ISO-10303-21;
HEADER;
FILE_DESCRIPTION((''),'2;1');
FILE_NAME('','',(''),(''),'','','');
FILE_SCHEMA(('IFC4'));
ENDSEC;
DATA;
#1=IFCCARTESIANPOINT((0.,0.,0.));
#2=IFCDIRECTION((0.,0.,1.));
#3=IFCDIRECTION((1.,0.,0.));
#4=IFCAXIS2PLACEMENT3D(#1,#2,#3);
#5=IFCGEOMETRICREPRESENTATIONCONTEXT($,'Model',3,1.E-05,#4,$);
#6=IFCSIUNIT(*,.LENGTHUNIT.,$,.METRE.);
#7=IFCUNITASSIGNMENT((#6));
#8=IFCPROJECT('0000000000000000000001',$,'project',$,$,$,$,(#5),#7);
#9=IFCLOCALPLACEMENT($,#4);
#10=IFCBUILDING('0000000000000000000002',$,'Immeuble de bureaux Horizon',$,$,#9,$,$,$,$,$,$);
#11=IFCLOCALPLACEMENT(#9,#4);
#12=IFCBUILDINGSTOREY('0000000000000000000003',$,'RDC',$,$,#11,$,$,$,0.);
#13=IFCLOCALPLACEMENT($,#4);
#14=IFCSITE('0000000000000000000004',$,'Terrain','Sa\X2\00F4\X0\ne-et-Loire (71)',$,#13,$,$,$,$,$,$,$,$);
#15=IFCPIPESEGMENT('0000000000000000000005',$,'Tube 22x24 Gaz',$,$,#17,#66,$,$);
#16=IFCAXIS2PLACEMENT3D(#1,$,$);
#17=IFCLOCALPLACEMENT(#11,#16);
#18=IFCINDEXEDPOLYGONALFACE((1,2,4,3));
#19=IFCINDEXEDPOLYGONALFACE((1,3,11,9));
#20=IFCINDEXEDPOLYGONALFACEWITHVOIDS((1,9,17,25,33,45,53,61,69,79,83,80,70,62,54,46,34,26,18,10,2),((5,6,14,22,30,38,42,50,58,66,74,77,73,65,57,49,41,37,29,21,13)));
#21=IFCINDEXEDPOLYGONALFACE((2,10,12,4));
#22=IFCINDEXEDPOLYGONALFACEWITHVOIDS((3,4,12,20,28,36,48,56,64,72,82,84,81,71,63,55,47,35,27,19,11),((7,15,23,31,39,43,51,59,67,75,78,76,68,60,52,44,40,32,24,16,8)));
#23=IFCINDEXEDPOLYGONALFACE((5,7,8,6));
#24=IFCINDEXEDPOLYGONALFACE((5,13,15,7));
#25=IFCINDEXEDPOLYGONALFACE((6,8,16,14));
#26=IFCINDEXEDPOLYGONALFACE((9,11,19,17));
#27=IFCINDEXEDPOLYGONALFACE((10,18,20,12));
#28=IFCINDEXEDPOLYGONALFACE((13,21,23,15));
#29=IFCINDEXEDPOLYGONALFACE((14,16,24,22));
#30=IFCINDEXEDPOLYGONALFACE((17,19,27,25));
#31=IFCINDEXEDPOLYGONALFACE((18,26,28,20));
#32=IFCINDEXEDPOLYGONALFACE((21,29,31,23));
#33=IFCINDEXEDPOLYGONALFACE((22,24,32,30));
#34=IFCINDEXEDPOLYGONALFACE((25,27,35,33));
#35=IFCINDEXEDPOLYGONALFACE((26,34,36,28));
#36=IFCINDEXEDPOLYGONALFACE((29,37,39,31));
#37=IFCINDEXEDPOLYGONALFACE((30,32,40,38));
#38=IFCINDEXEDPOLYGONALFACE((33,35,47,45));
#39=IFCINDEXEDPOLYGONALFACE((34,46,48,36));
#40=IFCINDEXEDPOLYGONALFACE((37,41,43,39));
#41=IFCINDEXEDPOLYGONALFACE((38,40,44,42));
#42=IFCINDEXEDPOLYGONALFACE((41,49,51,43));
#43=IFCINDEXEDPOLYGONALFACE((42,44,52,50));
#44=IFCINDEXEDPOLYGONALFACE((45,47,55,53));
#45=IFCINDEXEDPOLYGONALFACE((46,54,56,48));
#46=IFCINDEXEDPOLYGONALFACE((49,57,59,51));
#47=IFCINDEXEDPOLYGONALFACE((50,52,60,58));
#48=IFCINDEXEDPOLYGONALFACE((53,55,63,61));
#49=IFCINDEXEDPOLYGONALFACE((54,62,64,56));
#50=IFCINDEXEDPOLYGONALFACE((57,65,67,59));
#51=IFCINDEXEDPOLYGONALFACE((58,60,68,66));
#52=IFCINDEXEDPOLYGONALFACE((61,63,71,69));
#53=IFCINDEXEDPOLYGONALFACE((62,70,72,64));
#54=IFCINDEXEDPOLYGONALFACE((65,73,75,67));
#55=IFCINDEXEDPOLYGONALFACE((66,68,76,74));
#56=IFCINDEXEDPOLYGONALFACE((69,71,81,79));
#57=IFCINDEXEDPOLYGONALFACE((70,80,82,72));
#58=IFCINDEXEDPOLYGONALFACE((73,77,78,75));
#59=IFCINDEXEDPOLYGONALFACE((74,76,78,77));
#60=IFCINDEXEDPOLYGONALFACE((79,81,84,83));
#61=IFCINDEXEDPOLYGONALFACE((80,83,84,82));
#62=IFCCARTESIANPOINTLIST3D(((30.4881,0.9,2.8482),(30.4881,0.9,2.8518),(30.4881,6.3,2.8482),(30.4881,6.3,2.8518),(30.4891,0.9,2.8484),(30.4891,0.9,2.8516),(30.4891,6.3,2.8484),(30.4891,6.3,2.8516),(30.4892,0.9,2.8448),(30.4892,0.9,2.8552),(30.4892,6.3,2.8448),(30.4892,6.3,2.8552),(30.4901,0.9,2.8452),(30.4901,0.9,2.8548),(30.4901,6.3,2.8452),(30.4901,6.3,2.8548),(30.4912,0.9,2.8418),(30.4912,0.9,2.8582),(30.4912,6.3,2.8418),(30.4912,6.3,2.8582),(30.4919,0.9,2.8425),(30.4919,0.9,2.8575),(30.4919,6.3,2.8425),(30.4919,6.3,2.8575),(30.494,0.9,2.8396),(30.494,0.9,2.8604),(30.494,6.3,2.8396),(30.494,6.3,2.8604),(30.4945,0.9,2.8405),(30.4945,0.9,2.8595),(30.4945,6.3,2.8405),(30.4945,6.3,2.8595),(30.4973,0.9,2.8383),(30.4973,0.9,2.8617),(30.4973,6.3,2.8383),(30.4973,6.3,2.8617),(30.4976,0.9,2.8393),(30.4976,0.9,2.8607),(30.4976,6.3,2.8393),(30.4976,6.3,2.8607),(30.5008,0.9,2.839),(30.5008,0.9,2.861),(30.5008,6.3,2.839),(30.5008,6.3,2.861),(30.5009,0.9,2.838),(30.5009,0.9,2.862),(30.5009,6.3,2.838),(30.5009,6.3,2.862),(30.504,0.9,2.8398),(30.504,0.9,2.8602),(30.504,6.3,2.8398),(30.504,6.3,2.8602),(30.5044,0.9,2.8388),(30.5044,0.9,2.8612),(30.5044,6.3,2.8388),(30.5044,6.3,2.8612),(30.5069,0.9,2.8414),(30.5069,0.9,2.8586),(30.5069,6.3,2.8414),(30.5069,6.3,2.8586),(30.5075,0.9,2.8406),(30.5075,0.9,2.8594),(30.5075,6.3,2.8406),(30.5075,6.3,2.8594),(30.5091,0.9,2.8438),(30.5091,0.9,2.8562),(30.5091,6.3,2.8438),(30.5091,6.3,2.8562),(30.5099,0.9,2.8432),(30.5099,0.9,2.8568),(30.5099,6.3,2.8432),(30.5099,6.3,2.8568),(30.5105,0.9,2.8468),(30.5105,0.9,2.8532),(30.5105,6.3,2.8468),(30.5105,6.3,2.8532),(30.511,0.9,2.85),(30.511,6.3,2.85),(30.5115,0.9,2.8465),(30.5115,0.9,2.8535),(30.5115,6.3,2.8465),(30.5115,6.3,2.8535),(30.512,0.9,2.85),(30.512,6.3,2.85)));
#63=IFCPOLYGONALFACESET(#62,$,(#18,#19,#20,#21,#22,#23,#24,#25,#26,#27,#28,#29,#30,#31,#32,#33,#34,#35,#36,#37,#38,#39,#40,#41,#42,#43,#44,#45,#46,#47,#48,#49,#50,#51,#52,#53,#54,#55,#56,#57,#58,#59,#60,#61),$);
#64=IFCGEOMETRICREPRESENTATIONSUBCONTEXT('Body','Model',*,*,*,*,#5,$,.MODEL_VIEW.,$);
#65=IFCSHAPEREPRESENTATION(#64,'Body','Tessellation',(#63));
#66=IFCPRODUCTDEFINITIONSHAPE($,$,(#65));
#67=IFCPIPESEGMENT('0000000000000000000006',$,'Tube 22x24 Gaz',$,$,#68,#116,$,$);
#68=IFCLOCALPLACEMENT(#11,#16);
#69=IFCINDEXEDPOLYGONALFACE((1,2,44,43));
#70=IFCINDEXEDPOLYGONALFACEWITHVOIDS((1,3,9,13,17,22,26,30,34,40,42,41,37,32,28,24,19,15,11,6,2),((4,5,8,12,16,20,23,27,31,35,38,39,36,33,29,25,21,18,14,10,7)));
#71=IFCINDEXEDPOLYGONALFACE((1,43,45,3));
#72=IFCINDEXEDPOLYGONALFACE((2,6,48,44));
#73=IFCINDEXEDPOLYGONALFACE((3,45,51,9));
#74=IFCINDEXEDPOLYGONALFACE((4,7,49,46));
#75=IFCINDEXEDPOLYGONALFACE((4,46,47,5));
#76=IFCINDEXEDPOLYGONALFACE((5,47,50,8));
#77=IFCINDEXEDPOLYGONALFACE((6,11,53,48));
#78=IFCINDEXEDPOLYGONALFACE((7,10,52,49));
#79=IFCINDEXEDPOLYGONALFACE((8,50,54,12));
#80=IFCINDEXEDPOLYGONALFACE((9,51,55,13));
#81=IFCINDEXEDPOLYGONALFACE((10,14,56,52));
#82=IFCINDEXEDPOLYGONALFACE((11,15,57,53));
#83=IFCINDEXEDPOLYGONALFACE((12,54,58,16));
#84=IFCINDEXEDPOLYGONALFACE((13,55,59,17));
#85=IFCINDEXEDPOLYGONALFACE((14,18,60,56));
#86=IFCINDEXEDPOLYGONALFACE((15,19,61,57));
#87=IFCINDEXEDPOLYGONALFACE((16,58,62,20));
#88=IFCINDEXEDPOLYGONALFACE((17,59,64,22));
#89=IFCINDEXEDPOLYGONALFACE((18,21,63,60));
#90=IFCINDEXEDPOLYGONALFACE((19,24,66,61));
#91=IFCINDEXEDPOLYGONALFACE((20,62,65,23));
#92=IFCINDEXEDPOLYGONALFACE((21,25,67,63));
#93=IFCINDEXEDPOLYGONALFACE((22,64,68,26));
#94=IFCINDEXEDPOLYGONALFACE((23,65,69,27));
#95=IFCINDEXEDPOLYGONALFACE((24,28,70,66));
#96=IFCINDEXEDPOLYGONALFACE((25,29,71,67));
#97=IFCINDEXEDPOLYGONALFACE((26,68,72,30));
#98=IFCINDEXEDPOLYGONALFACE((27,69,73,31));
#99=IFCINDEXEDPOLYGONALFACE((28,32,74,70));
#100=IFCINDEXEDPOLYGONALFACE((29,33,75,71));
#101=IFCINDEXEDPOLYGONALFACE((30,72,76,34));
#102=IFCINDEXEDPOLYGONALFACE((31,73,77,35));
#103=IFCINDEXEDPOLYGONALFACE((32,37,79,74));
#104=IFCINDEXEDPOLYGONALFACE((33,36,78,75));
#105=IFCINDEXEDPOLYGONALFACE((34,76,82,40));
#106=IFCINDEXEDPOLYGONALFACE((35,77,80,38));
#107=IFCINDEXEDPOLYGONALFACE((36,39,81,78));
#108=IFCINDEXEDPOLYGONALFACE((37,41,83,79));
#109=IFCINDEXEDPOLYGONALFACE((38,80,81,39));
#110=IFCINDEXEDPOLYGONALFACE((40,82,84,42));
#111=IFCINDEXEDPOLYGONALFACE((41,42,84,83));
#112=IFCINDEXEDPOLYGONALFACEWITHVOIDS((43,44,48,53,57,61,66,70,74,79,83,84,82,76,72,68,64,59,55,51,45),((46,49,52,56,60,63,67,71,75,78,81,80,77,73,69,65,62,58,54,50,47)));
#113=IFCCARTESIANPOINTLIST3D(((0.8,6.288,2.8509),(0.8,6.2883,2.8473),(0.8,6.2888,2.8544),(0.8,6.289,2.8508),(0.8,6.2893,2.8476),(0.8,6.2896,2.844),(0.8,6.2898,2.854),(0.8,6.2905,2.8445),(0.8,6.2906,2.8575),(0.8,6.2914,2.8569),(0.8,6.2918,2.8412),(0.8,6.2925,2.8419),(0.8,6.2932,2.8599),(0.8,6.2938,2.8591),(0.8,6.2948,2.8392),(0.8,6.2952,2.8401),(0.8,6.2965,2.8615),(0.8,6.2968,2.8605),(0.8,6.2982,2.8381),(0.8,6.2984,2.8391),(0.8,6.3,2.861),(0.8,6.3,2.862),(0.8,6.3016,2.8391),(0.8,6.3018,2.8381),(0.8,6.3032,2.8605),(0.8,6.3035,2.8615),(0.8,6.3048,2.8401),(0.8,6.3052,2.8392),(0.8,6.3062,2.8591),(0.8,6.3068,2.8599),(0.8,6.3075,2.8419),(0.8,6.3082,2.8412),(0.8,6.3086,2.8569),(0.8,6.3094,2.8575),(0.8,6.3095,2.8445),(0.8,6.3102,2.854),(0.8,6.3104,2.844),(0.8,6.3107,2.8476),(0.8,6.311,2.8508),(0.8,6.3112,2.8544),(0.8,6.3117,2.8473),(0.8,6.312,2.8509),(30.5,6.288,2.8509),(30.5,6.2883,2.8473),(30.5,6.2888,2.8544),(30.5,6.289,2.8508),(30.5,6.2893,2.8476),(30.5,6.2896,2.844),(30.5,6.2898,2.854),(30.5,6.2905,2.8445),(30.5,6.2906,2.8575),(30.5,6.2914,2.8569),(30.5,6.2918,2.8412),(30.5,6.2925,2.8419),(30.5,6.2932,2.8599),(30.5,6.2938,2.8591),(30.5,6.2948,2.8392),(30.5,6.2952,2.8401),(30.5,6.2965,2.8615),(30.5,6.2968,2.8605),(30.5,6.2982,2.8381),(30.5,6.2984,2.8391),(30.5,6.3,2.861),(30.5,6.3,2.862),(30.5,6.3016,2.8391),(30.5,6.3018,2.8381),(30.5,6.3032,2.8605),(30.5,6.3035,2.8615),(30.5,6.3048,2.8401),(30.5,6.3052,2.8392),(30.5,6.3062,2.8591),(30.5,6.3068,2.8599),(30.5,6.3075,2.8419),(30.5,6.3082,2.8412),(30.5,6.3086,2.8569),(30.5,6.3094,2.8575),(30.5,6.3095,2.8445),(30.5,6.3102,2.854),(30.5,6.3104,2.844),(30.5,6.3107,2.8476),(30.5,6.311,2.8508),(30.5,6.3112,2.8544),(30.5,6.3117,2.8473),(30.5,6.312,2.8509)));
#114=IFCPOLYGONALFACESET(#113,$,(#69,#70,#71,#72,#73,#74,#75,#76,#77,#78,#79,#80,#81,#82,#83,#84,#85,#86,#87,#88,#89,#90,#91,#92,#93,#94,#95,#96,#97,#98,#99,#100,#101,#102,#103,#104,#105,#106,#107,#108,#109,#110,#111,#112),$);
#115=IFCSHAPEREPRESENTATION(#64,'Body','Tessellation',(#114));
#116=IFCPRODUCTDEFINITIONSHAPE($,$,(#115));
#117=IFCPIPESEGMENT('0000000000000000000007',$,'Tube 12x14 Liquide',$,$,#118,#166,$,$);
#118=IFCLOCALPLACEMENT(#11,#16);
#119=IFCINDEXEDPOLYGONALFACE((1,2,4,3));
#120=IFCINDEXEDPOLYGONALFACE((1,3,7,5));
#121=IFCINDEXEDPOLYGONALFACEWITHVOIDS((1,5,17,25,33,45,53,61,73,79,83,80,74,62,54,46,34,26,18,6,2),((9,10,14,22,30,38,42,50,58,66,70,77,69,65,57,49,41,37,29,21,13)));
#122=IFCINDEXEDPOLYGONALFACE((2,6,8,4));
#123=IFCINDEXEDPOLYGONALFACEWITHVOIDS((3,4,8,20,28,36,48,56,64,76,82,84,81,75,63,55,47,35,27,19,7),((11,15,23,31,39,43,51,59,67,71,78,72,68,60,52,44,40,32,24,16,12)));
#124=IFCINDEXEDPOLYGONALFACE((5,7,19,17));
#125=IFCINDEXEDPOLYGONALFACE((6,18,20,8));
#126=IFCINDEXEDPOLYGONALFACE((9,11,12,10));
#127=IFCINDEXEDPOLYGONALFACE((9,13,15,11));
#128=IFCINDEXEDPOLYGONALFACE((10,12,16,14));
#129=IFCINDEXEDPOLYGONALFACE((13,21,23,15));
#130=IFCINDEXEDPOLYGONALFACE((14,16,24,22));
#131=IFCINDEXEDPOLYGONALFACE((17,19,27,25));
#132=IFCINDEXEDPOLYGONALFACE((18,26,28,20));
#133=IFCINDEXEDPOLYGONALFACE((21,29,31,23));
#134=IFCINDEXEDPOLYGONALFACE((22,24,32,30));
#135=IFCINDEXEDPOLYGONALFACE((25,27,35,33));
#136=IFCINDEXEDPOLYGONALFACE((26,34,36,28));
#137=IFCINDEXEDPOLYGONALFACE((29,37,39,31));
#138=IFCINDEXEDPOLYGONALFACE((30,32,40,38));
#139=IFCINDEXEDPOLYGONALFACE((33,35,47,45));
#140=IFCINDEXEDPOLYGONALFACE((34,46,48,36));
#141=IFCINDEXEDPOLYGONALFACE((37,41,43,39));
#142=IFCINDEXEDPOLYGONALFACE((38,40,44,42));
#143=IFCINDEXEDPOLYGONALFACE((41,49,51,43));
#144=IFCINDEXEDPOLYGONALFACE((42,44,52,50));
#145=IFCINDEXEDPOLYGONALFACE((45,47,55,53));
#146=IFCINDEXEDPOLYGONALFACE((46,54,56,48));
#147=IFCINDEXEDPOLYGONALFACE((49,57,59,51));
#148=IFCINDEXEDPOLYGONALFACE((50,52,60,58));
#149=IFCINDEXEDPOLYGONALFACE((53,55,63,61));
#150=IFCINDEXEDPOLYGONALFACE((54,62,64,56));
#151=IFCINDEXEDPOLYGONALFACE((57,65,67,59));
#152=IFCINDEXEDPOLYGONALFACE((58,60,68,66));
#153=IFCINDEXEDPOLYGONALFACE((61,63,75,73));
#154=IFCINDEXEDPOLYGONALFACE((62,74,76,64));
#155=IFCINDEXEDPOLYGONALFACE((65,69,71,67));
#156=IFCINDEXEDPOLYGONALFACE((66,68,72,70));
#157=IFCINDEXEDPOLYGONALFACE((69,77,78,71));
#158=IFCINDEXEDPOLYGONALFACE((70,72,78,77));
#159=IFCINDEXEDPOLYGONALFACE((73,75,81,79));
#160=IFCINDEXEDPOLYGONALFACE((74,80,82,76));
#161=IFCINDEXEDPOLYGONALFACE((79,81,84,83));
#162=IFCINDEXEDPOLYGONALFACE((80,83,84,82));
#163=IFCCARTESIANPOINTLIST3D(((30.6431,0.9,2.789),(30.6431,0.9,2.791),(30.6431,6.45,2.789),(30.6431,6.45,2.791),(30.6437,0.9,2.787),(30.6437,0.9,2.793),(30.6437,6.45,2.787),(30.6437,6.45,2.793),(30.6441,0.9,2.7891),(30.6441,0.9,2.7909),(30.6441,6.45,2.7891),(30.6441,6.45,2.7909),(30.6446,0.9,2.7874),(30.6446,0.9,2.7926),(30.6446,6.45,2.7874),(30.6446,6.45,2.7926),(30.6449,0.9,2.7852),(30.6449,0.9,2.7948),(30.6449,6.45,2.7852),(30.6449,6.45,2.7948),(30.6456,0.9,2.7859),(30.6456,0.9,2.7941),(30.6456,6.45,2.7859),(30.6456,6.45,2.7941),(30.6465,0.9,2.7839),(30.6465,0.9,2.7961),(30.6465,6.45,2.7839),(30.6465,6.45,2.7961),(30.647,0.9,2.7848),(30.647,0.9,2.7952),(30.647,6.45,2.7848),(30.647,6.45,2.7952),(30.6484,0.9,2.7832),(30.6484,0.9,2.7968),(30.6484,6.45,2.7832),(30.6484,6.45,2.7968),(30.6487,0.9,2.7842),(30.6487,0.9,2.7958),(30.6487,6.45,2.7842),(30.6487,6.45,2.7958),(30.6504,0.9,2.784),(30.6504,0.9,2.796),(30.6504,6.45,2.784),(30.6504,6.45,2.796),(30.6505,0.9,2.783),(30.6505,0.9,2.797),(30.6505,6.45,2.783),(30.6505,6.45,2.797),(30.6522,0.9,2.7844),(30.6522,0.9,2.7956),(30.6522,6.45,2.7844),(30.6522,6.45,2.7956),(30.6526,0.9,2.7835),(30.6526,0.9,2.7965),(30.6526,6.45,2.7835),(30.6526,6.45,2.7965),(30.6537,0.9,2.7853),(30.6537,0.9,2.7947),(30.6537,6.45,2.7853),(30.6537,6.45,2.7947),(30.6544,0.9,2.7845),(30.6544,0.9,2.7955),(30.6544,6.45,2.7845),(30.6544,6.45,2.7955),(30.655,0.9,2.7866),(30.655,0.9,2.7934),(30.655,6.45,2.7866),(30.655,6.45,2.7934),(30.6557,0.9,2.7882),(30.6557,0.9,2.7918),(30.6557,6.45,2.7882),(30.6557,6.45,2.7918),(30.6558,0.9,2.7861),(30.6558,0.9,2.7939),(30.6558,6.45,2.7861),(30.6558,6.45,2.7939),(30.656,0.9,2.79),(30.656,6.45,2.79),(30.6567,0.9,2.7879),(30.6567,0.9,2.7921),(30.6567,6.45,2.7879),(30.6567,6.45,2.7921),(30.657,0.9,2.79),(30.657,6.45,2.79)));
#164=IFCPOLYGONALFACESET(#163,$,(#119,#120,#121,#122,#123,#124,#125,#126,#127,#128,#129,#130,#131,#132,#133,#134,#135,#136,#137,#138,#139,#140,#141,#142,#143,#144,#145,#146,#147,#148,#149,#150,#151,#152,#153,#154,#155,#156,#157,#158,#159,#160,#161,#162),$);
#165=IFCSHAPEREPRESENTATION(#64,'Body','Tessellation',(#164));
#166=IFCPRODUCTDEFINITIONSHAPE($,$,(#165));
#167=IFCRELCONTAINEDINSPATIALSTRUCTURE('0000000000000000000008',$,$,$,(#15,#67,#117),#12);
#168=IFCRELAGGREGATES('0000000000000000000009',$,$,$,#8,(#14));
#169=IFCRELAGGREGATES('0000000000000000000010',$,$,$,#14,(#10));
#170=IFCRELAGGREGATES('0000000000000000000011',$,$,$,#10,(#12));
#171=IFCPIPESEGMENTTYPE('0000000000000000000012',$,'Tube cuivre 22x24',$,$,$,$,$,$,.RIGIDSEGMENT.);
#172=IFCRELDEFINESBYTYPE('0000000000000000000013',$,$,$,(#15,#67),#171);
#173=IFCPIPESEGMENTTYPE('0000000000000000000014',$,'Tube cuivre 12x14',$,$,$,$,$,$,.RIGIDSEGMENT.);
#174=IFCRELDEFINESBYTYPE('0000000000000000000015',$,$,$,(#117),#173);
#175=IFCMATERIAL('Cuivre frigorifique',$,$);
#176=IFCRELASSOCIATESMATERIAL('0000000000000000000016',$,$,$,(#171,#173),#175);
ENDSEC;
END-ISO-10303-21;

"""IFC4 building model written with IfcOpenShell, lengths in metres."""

from ifc_helpers import new_model, si_unit, frame, origin_with_axes, place, context, subcontext, project, spatial, hollow_circle, extrude, material, type_object, element, save


model = new_model("IFC4")

# Units and contexts
model_context = context("Model", 3, precision=1e-05, world=origin_with_axes())
body_context = subcontext(model_context, "Body", "Model", "MODEL_VIEW")
ifc_project = project(units=[si_unit("LENGTHUNIT", "METRE")], contexts=[model_context])

# Site, building, storey
site_placement = place(None, origin_with_axes())
site = spatial("IfcSite", under=ifc_project, at=site_placement, Name="Terrain", Description="Saône-et-Loire (71)")
building_placement = place(None, origin_with_axes())
building = spatial("IfcBuilding", under=site, at=building_placement, Name="Immeuble de bureaux Horizon")
storey_placement = place(building_placement, origin_with_axes())
storey = spatial("IfcBuildingStorey", under=building, at=storey_placement, Name="RDC", Elevation=0.0)

# Shared definitions
ifc_material_1 = material(Name="Cuivre frigorifique")

# Pipe segments
pipe_segment_type_1 = type_object("IfcPipeSegmentType", Name="Tube cuivre 22x24", PredefinedType="RIGIDSEGMENT", material=ifc_material_1)
pipe_segment_1_placement = place(storey_placement, frame((30.5, 0.9, 2.85), z_axis=(0.0, 1.0, 0.0), x_axis=(1.0, 0.0, 0.0)))
element("IfcPipeSegment", 1, at=pipe_segment_1_placement, inside=storey, type_object=pipe_segment_type_1, Name="Tube 22x24 Gaz", context=body_context, shape_type="SweptSolid", body=[
    extrude(hollow_circle(Radius=0.012, WallThickness=0.001), origin_with_axes(), (0.0, 0.0, 1.0), 5.4),
])
pipe_segment_2_placement = place(storey_placement, frame((30.5, 6.3, 2.85), z_axis=(-1.0, 0.0, 0.0), x_axis=(0.0, 0.0, 1.0)))
element("IfcPipeSegment", 2, at=pipe_segment_2_placement, inside=storey, type_object=pipe_segment_type_1, Name="Tube 22x24 Gaz", context=body_context, shape_type="SweptSolid", body=[
    extrude(hollow_circle(Radius=0.012, WallThickness=0.001), origin_with_axes(), (0.0, 0.0, 1.0), 29.7),
])
pipe_segment_type_2 = type_object("IfcPipeSegmentType", Name="Tube cuivre 12x14", PredefinedType="RIGIDSEGMENT", material=ifc_material_1)
pipe_segment_3_placement = place(storey_placement, frame((30.65, 0.9, 2.79), z_axis=(0.0, 1.0, 0.0), x_axis=(1.0, 0.0, 0.0)))
element("IfcPipeSegment", 3, at=pipe_segment_3_placement, inside=storey, type_object=pipe_segment_type_2, Name="Tube 12x14 Liquide", context=body_context, shape_type="SweptSolid", body=[
    extrude(hollow_circle(Radius=0.007, WallThickness=0.001), origin_with_axes(), (0.0, 0.0, 1.0), 5.55),
])

save(model, "model.ifc")
